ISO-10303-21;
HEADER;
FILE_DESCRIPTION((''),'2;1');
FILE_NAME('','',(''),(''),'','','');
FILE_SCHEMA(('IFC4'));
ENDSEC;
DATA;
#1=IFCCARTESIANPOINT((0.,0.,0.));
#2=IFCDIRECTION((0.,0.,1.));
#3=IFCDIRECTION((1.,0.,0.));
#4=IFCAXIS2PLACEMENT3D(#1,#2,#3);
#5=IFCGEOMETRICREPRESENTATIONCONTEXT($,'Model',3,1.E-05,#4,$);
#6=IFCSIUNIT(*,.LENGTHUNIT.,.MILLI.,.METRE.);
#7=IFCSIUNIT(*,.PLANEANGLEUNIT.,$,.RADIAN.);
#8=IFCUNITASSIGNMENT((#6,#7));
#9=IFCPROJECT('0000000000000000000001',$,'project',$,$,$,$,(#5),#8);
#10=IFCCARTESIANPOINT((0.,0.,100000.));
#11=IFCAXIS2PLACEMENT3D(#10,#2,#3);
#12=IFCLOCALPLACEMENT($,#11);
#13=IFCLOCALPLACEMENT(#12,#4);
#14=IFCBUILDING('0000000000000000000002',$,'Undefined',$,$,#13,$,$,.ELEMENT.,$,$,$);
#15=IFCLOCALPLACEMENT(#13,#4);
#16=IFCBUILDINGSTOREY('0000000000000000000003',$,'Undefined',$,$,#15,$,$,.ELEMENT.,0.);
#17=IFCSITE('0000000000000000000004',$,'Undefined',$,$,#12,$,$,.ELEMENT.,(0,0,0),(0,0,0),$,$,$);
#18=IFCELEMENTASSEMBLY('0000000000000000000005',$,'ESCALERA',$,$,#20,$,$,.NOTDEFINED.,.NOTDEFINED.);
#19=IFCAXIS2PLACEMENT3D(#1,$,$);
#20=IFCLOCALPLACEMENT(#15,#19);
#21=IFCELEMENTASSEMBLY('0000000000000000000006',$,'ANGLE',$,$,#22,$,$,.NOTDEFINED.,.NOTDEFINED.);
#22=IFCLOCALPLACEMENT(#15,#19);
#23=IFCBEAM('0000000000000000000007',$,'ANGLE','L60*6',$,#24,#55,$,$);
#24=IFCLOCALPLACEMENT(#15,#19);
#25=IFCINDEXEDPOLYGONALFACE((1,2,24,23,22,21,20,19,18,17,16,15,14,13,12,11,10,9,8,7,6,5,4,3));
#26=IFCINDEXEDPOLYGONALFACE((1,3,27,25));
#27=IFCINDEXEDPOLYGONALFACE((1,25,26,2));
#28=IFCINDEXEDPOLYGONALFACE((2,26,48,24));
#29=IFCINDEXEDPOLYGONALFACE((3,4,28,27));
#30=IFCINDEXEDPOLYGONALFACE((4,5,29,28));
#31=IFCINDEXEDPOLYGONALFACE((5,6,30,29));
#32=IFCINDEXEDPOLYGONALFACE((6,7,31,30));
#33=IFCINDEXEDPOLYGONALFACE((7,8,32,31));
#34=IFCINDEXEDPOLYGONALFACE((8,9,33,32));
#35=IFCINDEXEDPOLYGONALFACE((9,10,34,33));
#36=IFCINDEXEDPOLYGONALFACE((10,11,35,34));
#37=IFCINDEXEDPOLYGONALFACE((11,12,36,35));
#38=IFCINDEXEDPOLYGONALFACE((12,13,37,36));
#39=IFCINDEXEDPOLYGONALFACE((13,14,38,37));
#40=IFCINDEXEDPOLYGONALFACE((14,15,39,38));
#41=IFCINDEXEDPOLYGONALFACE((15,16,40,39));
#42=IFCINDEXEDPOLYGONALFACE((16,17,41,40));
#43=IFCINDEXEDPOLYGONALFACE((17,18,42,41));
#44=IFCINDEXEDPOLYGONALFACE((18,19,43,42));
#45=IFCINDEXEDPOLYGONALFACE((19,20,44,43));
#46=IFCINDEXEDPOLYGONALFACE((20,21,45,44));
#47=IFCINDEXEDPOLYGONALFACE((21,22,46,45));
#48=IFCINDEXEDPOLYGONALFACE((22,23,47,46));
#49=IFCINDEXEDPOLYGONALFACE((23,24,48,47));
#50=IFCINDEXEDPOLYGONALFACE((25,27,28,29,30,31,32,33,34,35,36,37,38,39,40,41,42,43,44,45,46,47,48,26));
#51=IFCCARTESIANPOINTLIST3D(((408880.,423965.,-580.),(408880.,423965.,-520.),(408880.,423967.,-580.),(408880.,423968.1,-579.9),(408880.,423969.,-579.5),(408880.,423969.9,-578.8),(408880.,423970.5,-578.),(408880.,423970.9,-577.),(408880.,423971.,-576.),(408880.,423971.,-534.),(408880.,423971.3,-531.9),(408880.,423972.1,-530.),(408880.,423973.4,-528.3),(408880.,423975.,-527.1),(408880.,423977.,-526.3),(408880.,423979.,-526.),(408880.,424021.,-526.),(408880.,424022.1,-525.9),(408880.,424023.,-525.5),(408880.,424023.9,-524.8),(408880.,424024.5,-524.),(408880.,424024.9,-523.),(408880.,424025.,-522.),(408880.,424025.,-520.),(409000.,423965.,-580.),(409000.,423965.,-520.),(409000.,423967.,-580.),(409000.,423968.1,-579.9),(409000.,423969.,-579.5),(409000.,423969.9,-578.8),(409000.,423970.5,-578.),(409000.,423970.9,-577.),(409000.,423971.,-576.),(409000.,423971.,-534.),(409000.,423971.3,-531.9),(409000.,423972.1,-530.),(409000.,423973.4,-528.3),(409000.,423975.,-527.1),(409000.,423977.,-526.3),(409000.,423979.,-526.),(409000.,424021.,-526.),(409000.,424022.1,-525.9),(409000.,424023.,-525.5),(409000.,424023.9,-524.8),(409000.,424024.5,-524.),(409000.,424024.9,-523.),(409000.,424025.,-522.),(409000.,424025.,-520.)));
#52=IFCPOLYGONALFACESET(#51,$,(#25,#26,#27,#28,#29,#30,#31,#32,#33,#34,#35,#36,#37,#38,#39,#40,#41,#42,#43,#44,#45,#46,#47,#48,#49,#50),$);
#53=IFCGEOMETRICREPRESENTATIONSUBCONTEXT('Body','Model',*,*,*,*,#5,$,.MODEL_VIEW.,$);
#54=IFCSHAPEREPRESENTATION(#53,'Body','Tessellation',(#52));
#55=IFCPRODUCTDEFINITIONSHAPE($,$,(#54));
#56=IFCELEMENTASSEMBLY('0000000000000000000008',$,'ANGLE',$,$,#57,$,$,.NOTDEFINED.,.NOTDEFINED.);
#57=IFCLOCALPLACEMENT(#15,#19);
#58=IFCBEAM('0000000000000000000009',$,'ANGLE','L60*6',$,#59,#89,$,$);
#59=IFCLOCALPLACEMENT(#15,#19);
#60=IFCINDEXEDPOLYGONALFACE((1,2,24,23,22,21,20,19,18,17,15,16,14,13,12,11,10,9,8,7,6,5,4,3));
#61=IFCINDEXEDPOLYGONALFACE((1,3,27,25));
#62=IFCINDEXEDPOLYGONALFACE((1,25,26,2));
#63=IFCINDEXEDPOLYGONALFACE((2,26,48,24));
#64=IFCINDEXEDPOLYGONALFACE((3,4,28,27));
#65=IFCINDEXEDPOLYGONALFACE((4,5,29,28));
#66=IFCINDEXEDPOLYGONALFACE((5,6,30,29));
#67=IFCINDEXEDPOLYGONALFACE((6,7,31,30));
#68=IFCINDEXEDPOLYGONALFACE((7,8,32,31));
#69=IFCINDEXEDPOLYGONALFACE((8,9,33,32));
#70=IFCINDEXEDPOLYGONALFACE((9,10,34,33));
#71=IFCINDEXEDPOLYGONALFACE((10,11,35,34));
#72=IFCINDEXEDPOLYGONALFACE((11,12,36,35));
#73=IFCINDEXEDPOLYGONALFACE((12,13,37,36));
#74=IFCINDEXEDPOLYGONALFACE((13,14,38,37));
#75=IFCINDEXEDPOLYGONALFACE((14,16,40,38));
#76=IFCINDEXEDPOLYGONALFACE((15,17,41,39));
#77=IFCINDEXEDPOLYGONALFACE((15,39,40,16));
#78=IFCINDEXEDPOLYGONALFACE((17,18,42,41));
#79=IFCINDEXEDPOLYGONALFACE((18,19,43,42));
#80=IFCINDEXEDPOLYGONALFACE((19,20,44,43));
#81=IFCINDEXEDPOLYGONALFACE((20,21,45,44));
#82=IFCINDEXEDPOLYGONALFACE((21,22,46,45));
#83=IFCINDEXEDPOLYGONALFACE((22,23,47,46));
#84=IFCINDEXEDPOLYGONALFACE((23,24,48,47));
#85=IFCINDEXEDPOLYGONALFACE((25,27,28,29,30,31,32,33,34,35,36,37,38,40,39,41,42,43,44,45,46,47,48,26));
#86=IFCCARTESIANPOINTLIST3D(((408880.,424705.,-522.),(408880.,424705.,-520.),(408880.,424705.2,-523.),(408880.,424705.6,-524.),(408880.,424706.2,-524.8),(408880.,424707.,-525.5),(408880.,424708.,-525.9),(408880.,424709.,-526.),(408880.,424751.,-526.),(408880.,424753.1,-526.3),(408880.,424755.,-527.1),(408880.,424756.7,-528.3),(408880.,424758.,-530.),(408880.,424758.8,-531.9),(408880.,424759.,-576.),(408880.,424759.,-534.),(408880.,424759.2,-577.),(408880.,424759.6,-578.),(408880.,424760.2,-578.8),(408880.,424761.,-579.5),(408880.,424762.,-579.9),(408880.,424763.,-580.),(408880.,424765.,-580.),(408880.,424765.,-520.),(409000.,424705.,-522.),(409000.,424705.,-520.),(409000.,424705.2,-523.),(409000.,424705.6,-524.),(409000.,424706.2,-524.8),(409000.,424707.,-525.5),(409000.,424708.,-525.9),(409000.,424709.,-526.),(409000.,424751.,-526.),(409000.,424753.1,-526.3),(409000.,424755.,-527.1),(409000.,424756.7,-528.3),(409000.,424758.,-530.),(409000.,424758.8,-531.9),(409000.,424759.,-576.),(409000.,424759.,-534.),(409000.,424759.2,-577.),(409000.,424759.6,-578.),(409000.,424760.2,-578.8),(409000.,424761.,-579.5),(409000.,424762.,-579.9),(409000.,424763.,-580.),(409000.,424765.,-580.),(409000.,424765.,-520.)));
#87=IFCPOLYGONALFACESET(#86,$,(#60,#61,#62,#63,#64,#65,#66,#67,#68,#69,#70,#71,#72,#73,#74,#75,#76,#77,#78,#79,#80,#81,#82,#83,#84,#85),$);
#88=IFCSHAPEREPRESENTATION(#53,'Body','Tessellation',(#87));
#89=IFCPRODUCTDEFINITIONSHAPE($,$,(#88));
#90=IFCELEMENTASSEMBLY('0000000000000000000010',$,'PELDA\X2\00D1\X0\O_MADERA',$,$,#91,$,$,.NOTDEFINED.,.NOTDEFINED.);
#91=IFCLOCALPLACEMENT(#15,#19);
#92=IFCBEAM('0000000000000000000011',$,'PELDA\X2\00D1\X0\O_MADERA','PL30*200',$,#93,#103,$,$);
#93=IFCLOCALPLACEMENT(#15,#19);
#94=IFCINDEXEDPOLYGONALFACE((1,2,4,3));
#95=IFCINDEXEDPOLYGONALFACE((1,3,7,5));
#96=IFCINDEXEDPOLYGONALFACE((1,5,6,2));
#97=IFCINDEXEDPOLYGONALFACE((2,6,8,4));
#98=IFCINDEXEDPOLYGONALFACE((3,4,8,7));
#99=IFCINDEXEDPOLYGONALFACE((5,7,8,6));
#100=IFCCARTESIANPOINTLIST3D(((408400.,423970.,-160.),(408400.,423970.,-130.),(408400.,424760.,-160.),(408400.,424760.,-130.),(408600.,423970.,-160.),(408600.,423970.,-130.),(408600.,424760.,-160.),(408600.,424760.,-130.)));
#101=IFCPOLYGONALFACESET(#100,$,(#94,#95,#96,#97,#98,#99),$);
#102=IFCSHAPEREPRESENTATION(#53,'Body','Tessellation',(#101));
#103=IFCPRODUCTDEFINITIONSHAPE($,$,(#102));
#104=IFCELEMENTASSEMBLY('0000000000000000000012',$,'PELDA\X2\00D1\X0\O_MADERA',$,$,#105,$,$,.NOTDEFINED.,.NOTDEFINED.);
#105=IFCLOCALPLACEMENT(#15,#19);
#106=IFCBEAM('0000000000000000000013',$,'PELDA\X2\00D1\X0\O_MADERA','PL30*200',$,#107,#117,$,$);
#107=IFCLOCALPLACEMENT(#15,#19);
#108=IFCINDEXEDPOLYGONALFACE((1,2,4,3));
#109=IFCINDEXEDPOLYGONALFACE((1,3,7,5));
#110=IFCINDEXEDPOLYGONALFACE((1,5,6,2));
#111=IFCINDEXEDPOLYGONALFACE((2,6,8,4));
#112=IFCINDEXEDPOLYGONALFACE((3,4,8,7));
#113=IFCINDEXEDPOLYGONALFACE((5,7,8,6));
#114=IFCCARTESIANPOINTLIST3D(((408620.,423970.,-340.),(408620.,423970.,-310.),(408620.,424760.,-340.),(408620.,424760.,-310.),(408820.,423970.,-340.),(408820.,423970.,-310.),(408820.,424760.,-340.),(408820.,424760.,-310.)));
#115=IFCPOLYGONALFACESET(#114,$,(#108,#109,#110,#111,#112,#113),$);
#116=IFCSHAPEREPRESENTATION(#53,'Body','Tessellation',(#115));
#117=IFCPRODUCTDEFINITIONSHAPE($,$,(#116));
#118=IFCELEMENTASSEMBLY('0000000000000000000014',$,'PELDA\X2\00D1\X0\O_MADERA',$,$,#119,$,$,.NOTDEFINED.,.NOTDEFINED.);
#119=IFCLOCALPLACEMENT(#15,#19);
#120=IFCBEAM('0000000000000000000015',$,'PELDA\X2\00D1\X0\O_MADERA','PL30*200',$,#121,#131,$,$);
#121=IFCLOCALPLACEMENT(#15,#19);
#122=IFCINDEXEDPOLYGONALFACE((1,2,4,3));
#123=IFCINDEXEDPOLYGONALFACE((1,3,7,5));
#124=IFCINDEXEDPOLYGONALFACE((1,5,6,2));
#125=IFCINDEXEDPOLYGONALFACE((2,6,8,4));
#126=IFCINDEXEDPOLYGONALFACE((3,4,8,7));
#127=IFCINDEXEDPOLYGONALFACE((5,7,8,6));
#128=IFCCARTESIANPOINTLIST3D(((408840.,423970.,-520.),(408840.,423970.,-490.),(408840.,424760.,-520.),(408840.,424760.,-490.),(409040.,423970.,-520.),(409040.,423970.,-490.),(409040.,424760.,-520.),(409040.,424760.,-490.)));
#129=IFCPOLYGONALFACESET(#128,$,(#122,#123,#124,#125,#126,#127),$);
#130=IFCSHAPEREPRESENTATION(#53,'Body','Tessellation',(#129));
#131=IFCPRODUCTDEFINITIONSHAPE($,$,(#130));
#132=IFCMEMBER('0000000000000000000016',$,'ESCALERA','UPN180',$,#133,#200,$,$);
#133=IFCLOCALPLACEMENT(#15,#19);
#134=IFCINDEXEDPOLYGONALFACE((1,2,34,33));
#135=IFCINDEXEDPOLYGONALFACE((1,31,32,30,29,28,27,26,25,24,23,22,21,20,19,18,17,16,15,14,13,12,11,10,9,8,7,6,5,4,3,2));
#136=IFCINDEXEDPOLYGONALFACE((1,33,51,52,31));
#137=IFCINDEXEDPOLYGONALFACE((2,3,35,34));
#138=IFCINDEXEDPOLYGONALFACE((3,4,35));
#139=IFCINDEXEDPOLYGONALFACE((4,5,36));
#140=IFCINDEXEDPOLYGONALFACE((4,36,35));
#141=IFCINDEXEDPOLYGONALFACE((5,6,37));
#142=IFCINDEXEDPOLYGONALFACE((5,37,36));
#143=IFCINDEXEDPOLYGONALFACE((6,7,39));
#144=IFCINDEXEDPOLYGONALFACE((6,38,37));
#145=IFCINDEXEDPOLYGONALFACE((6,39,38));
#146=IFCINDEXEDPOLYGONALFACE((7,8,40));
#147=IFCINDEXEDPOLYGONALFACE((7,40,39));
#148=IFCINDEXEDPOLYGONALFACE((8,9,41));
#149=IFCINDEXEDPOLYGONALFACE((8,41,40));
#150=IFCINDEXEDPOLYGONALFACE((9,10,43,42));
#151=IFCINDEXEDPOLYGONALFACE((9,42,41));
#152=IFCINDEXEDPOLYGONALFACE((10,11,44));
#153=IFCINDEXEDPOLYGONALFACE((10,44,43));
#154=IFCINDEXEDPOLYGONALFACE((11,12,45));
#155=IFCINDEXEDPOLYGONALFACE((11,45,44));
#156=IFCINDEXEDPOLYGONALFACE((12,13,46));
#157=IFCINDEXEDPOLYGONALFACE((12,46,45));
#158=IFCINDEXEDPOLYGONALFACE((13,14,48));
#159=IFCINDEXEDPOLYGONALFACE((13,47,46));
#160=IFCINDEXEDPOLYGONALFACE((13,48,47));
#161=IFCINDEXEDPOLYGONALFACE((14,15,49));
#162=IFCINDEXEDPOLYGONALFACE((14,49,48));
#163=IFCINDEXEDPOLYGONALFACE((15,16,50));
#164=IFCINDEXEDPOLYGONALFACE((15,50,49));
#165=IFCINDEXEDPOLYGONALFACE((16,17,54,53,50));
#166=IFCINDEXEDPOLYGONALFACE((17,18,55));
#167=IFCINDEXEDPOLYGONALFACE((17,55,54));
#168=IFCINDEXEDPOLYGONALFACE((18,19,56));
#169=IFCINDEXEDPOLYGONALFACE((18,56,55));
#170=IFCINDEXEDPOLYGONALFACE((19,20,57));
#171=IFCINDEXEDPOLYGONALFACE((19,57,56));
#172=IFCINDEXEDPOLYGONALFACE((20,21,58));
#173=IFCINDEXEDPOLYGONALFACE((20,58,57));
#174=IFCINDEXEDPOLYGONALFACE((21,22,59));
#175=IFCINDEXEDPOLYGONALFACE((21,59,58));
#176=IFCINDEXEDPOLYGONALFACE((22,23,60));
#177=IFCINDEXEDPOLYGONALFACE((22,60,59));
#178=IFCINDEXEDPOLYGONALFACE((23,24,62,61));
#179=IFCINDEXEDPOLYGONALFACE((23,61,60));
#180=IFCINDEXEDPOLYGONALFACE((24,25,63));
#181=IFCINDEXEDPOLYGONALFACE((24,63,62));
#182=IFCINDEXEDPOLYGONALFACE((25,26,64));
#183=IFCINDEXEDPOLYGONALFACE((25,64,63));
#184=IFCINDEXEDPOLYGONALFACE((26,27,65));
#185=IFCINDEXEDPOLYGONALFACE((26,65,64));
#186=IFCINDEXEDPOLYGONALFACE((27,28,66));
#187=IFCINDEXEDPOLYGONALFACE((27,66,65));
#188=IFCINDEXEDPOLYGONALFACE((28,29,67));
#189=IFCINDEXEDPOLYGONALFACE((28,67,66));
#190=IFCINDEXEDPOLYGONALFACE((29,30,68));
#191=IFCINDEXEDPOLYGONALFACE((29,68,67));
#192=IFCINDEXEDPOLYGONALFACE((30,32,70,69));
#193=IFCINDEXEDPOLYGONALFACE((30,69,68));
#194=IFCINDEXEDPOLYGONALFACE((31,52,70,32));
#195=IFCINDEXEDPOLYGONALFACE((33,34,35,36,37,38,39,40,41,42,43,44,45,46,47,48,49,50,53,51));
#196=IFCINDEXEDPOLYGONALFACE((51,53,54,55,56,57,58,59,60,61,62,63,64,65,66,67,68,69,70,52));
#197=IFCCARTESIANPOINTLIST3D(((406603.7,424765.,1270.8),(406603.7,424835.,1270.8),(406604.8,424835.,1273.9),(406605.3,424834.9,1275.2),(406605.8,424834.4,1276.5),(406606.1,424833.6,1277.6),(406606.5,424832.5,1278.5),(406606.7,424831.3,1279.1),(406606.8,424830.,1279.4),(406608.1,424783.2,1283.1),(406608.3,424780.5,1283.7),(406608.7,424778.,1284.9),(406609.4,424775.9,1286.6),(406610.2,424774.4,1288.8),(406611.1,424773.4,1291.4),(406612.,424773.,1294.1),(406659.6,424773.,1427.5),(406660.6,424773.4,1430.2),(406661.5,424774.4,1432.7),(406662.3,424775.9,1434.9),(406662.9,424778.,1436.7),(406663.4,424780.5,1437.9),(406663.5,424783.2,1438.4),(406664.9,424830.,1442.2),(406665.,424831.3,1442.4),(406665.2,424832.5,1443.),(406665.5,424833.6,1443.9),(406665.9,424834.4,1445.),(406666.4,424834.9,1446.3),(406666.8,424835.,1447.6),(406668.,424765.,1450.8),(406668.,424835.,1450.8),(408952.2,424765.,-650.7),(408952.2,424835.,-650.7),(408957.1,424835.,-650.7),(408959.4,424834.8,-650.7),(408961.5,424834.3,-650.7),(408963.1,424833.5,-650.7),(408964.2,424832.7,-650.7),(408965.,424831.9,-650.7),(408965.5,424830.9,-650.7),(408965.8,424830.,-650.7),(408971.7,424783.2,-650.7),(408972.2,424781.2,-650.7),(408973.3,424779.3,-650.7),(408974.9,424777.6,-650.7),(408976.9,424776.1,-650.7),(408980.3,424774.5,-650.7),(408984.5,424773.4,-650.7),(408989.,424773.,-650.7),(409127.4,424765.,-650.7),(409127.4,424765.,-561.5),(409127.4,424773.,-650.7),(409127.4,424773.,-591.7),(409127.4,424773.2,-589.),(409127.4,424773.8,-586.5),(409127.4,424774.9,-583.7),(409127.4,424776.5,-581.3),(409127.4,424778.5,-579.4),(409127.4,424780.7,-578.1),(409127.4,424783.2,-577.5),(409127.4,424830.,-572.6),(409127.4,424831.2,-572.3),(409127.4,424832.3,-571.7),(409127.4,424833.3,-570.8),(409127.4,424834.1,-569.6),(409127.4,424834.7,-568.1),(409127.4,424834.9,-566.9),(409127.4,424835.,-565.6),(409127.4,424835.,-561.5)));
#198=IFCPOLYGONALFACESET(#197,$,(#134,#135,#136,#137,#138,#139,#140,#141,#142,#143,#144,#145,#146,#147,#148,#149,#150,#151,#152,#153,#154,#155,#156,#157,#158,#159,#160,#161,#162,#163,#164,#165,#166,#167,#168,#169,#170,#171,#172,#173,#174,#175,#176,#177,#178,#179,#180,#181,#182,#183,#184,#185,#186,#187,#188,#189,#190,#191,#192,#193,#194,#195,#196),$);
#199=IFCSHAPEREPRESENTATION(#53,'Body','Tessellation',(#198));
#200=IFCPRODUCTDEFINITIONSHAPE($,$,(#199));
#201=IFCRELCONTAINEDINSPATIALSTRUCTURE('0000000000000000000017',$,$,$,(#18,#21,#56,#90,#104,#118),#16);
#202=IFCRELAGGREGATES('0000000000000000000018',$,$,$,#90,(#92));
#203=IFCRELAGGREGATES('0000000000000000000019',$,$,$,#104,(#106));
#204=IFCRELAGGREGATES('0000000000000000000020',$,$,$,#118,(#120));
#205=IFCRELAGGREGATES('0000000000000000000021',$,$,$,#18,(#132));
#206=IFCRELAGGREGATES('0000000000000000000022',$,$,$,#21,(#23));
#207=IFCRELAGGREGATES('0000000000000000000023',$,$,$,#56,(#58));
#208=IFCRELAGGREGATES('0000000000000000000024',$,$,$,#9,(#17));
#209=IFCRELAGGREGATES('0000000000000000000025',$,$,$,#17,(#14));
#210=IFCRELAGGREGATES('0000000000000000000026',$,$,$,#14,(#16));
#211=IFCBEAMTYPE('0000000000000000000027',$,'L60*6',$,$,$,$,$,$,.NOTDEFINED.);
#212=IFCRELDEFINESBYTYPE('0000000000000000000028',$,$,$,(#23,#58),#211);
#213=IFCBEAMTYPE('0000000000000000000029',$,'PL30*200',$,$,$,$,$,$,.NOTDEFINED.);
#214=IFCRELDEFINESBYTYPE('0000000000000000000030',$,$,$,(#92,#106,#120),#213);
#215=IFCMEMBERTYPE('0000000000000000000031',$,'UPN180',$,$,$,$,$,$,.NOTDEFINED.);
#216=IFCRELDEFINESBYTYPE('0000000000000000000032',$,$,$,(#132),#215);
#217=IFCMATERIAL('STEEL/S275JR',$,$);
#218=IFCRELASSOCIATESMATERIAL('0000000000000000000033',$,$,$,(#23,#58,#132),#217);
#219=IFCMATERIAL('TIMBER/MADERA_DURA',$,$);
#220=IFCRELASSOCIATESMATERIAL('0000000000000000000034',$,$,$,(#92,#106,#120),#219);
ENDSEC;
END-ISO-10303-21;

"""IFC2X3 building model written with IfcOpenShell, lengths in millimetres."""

from ifc_helpers import new_model, si_unit, frame, origin_with_axes, origin_2d_with_axis, place, context, subcontext, project, spatial, rectangle, l_section, u_section, extrude, clip, halfspace, material, type_object, element, aggregate, save


model = new_model("IFC2X3")

# Units and contexts
model_context = context("Model", 3, precision=1e-05, world=origin_with_axes())
body_context = subcontext(model_context, "Body", "Model", "MODEL_VIEW")
ifc_project = project(units=[si_unit("LENGTHUNIT", "METRE", prefix="MILLI"), si_unit("PLANEANGLEUNIT", "RADIAN")], contexts=[model_context])

# Site, building, storey
site_placement = place(None, frame((0.0, 0.0, 100000.0), z_axis=(0.0, 0.0, 1.0), x_axis=(1.0, 0.0, 0.0)))
site = spatial("IfcSite", under=ifc_project, at=site_placement, Name="Undefined", CompositionType="ELEMENT", RefLatitude=(0, 0, 0), RefLongitude=(0, 0, 0))
building_placement = place(site_placement, origin_with_axes())
building = spatial("IfcBuilding", under=site, at=building_placement, Name="Undefined", CompositionType="ELEMENT")
storey_placement = place(building_placement, origin_with_axes())
storey = spatial("IfcBuildingStorey", under=building, at=storey_placement, Name="Undefined", CompositionType="ELEMENT", Elevation=0.0)

# Element assembly
assembly_1_placement = place(storey_placement, origin_with_axes())
assembly_1 = element("IfcElementAssembly", 1, at=assembly_1_placement, inside=storey, Name="ESCALERA", AssemblyPlace="NOTDEFINED", PredefinedType="NOTDEFINED")
ifc_material_1 = material(Name="STEEL/S275JR")

# Element assemblies, beams
beam_type_1 = type_object("IfcBeamType", Name="L60*6", PredefinedType="NOTDEFINED")
assembly_2_placement = place(storey_placement, origin_with_axes())
assembly_2 = element("IfcElementAssembly", 2, at=assembly_2_placement, inside=storey, Name="ANGLE", AssemblyPlace="NOTDEFINED", PredefinedType="NOTDEFINED")
beam_1_placement = place(assembly_2_placement, frame((409000.0, 423995.0, -550.0), z_axis=(0.0, 1.0, 0.0), x_axis=(-1.0, 0.0, 0.0)))
beam_1 = element("IfcBeam", 3, at=beam_1_placement, type_object=beam_type_1, material=ifc_material_1, Name="ANGLE", Description="L60*6", context=body_context, shape_type="SweptSolid", body=[
    extrude(l_section(Depth=60.0, Width=60.0, Thickness=6.0, FilletRadius=8.0, EdgeRadius=4.0, at=origin_2d_with_axis()), frame((120.0, 0.0, 0.0), z_axis=(-1.0, 0.0, 0.0), x_axis=(0.0, -1.0, 0.0)), (0.0, 0.0, 1.0), 120.0),
])
assembly_3_placement = place(storey_placement, origin_with_axes())
assembly_3 = element("IfcElementAssembly", 4, at=assembly_3_placement, inside=storey, Name="ANGLE", AssemblyPlace="NOTDEFINED", PredefinedType="NOTDEFINED")
beam_2_placement = place(assembly_3_placement, frame((408880.0, 424735.0, -550.0), z_axis=(0.0, -1.0, 0.0), x_axis=(1.0, 0.0, 0.0)))
beam_2 = element("IfcBeam", 5, at=beam_2_placement, type_object=beam_type_1, material=ifc_material_1, Name="ANGLE", Description="L60*6", context=body_context, shape_type="SweptSolid", body=[
    extrude(l_section(Depth=60.0, Width=60.0, Thickness=6.0, FilletRadius=8.0, EdgeRadius=4.0, at=origin_2d_with_axis()), frame((120.0, 0.0, 0.0), z_axis=(-1.0, 0.0, 0.0), x_axis=(0.0, -1.0, 0.0)), (0.0, 0.0, 1.0), 120.0),
])
assembly_4_placement = place(storey_placement, origin_with_axes())
assembly_4 = element("IfcElementAssembly", 6, at=assembly_4_placement, inside=storey, Name="PELDAÑO_MADERA", AssemblyPlace="NOTDEFINED", PredefinedType="NOTDEFINED")
ifc_material_2 = material(Name="TIMBER/MADERA_DURA")
beam_type_2 = type_object("IfcBeamType", Name="PL30*200", PredefinedType="NOTDEFINED")
beam_3_placement = place(assembly_4_placement, frame((408500.0, 424760.0, -145.0), z_axis=(-1.0, 0.0, 0.0), x_axis=(0.0, -1.0, 0.0)))
beam_3 = element("IfcBeam", 7, at=beam_3_placement, type_object=beam_type_2, material=ifc_material_2, Name="PELDAÑO_MADERA", Description="PL30*200", context=body_context, shape_type="SweptSolid", body=[
    extrude(rectangle(XDim=30.0, YDim=200.0, at=origin_2d_with_axis()), frame((790.0, 0.0, 0.0), z_axis=(-1.0, 0.0, 0.0), x_axis=(0.0, -1.0, 0.0)), (0.0, 0.0, 1.0), 790.0),
])
aggregate(assembly_4, [beam_3])
assembly_5_placement = place(storey_placement, origin_with_axes())
assembly_5 = element("IfcElementAssembly", 8, at=assembly_5_placement, inside=storey, Name="PELDAÑO_MADERA", AssemblyPlace="NOTDEFINED", PredefinedType="NOTDEFINED")
beam_4_placement = place(assembly_5_placement, frame((408720.0, 424760.0, -325.0), z_axis=(-1.0, 0.0, 0.0), x_axis=(0.0, -1.0, 0.0)))
beam_4 = element("IfcBeam", 9, at=beam_4_placement, type_object=beam_type_2, material=ifc_material_2, Name="PELDAÑO_MADERA", Description="PL30*200", context=body_context, shape_type="SweptSolid", body=[
    extrude(rectangle(XDim=30.0, YDim=200.0, at=origin_2d_with_axis()), frame((790.0, 0.0, 0.0), z_axis=(-1.0, 0.0, 0.0), x_axis=(0.0, -1.0, 0.0)), (0.0, 0.0, 1.0), 790.0),
])
aggregate(assembly_5, [beam_4])
assembly_6_placement = place(storey_placement, origin_with_axes())
assembly_6 = element("IfcElementAssembly", 10, at=assembly_6_placement, inside=storey, Name="PELDAÑO_MADERA", AssemblyPlace="NOTDEFINED", PredefinedType="NOTDEFINED")
beam_5_placement = place(assembly_6_placement, frame((408940.0, 424760.0, -505.0), z_axis=(-1.0, 0.0, 0.0), x_axis=(0.0, -1.0, 0.0)))
beam_5 = element("IfcBeam", 11, at=beam_5_placement, type_object=beam_type_2, material=ifc_material_2, Name="PELDAÑO_MADERA", Description="PL30*200", context=body_context, shape_type="SweptSolid", body=[
    extrude(rectangle(XDim=30.0, YDim=200.0, at=origin_2d_with_axis()), frame((790.0, 0.0, 0.0), z_axis=(-1.0, 0.0, 0.0), x_axis=(0.0, -1.0, 0.0)), (0.0, 0.0, 1.0), 790.0),
])
aggregate(assembly_6, [beam_5])

# Member
member_type = type_object("IfcMemberType", Name="UPN180", PredefinedType="NOTDEFINED")
member_placement = place(assembly_1_placement, frame((408970.4, 424800.0, -549.4), z_axis=(0.633238, 0.0, 0.773957), x_axis=(-0.773957, 0.0, 0.633238)))
member = element("IfcMember", 12, at=member_placement, type_object=member_type, material=ifc_material_1, Name="ESCALERA", Description="UPN180", context=body_context, shape_type="Clipping", body=[
    clip(clip(clip(extrude(u_section(Depth=180.0, FlangeWidth=70.0, WebThickness=8.0, FlangeThickness=11.0, FilletRadius=11.0, EdgeRadius=5.5, FlangeSlope=0.07983, at=origin_2d_with_axis()), frame((3125.0, 0.0, 0.0), z_axis=(-1.0, 0.0, 0.0), x_axis=(0.0, -1.0, 0.0)), (0.0, 0.0, 1.0), 3393.6), halfspace(frame((-276.5, 35.0, -90.0), z_axis=(-0.773957, 0.0, 0.633238), x_axis=(0.633238, 0.0, 0.773957)), False)), halfspace(frame((3039.7, -35.0, 65.2), z_axis=(-0.941795, 0.0, 0.336186), x_axis=(0.0, -1.0, 0.0)), True)), halfspace(frame((-108.3, -1035.0, -42.3), z_axis=(0.633238, 0.0, 0.773957), x_axis=(-0.773957, 0.0, 0.633238)), True)),
])
aggregate(assembly_1, [member])

aggregate(assembly_2, [beam_1])
aggregate(assembly_3, [beam_2])

save(model, "model.ifc")
